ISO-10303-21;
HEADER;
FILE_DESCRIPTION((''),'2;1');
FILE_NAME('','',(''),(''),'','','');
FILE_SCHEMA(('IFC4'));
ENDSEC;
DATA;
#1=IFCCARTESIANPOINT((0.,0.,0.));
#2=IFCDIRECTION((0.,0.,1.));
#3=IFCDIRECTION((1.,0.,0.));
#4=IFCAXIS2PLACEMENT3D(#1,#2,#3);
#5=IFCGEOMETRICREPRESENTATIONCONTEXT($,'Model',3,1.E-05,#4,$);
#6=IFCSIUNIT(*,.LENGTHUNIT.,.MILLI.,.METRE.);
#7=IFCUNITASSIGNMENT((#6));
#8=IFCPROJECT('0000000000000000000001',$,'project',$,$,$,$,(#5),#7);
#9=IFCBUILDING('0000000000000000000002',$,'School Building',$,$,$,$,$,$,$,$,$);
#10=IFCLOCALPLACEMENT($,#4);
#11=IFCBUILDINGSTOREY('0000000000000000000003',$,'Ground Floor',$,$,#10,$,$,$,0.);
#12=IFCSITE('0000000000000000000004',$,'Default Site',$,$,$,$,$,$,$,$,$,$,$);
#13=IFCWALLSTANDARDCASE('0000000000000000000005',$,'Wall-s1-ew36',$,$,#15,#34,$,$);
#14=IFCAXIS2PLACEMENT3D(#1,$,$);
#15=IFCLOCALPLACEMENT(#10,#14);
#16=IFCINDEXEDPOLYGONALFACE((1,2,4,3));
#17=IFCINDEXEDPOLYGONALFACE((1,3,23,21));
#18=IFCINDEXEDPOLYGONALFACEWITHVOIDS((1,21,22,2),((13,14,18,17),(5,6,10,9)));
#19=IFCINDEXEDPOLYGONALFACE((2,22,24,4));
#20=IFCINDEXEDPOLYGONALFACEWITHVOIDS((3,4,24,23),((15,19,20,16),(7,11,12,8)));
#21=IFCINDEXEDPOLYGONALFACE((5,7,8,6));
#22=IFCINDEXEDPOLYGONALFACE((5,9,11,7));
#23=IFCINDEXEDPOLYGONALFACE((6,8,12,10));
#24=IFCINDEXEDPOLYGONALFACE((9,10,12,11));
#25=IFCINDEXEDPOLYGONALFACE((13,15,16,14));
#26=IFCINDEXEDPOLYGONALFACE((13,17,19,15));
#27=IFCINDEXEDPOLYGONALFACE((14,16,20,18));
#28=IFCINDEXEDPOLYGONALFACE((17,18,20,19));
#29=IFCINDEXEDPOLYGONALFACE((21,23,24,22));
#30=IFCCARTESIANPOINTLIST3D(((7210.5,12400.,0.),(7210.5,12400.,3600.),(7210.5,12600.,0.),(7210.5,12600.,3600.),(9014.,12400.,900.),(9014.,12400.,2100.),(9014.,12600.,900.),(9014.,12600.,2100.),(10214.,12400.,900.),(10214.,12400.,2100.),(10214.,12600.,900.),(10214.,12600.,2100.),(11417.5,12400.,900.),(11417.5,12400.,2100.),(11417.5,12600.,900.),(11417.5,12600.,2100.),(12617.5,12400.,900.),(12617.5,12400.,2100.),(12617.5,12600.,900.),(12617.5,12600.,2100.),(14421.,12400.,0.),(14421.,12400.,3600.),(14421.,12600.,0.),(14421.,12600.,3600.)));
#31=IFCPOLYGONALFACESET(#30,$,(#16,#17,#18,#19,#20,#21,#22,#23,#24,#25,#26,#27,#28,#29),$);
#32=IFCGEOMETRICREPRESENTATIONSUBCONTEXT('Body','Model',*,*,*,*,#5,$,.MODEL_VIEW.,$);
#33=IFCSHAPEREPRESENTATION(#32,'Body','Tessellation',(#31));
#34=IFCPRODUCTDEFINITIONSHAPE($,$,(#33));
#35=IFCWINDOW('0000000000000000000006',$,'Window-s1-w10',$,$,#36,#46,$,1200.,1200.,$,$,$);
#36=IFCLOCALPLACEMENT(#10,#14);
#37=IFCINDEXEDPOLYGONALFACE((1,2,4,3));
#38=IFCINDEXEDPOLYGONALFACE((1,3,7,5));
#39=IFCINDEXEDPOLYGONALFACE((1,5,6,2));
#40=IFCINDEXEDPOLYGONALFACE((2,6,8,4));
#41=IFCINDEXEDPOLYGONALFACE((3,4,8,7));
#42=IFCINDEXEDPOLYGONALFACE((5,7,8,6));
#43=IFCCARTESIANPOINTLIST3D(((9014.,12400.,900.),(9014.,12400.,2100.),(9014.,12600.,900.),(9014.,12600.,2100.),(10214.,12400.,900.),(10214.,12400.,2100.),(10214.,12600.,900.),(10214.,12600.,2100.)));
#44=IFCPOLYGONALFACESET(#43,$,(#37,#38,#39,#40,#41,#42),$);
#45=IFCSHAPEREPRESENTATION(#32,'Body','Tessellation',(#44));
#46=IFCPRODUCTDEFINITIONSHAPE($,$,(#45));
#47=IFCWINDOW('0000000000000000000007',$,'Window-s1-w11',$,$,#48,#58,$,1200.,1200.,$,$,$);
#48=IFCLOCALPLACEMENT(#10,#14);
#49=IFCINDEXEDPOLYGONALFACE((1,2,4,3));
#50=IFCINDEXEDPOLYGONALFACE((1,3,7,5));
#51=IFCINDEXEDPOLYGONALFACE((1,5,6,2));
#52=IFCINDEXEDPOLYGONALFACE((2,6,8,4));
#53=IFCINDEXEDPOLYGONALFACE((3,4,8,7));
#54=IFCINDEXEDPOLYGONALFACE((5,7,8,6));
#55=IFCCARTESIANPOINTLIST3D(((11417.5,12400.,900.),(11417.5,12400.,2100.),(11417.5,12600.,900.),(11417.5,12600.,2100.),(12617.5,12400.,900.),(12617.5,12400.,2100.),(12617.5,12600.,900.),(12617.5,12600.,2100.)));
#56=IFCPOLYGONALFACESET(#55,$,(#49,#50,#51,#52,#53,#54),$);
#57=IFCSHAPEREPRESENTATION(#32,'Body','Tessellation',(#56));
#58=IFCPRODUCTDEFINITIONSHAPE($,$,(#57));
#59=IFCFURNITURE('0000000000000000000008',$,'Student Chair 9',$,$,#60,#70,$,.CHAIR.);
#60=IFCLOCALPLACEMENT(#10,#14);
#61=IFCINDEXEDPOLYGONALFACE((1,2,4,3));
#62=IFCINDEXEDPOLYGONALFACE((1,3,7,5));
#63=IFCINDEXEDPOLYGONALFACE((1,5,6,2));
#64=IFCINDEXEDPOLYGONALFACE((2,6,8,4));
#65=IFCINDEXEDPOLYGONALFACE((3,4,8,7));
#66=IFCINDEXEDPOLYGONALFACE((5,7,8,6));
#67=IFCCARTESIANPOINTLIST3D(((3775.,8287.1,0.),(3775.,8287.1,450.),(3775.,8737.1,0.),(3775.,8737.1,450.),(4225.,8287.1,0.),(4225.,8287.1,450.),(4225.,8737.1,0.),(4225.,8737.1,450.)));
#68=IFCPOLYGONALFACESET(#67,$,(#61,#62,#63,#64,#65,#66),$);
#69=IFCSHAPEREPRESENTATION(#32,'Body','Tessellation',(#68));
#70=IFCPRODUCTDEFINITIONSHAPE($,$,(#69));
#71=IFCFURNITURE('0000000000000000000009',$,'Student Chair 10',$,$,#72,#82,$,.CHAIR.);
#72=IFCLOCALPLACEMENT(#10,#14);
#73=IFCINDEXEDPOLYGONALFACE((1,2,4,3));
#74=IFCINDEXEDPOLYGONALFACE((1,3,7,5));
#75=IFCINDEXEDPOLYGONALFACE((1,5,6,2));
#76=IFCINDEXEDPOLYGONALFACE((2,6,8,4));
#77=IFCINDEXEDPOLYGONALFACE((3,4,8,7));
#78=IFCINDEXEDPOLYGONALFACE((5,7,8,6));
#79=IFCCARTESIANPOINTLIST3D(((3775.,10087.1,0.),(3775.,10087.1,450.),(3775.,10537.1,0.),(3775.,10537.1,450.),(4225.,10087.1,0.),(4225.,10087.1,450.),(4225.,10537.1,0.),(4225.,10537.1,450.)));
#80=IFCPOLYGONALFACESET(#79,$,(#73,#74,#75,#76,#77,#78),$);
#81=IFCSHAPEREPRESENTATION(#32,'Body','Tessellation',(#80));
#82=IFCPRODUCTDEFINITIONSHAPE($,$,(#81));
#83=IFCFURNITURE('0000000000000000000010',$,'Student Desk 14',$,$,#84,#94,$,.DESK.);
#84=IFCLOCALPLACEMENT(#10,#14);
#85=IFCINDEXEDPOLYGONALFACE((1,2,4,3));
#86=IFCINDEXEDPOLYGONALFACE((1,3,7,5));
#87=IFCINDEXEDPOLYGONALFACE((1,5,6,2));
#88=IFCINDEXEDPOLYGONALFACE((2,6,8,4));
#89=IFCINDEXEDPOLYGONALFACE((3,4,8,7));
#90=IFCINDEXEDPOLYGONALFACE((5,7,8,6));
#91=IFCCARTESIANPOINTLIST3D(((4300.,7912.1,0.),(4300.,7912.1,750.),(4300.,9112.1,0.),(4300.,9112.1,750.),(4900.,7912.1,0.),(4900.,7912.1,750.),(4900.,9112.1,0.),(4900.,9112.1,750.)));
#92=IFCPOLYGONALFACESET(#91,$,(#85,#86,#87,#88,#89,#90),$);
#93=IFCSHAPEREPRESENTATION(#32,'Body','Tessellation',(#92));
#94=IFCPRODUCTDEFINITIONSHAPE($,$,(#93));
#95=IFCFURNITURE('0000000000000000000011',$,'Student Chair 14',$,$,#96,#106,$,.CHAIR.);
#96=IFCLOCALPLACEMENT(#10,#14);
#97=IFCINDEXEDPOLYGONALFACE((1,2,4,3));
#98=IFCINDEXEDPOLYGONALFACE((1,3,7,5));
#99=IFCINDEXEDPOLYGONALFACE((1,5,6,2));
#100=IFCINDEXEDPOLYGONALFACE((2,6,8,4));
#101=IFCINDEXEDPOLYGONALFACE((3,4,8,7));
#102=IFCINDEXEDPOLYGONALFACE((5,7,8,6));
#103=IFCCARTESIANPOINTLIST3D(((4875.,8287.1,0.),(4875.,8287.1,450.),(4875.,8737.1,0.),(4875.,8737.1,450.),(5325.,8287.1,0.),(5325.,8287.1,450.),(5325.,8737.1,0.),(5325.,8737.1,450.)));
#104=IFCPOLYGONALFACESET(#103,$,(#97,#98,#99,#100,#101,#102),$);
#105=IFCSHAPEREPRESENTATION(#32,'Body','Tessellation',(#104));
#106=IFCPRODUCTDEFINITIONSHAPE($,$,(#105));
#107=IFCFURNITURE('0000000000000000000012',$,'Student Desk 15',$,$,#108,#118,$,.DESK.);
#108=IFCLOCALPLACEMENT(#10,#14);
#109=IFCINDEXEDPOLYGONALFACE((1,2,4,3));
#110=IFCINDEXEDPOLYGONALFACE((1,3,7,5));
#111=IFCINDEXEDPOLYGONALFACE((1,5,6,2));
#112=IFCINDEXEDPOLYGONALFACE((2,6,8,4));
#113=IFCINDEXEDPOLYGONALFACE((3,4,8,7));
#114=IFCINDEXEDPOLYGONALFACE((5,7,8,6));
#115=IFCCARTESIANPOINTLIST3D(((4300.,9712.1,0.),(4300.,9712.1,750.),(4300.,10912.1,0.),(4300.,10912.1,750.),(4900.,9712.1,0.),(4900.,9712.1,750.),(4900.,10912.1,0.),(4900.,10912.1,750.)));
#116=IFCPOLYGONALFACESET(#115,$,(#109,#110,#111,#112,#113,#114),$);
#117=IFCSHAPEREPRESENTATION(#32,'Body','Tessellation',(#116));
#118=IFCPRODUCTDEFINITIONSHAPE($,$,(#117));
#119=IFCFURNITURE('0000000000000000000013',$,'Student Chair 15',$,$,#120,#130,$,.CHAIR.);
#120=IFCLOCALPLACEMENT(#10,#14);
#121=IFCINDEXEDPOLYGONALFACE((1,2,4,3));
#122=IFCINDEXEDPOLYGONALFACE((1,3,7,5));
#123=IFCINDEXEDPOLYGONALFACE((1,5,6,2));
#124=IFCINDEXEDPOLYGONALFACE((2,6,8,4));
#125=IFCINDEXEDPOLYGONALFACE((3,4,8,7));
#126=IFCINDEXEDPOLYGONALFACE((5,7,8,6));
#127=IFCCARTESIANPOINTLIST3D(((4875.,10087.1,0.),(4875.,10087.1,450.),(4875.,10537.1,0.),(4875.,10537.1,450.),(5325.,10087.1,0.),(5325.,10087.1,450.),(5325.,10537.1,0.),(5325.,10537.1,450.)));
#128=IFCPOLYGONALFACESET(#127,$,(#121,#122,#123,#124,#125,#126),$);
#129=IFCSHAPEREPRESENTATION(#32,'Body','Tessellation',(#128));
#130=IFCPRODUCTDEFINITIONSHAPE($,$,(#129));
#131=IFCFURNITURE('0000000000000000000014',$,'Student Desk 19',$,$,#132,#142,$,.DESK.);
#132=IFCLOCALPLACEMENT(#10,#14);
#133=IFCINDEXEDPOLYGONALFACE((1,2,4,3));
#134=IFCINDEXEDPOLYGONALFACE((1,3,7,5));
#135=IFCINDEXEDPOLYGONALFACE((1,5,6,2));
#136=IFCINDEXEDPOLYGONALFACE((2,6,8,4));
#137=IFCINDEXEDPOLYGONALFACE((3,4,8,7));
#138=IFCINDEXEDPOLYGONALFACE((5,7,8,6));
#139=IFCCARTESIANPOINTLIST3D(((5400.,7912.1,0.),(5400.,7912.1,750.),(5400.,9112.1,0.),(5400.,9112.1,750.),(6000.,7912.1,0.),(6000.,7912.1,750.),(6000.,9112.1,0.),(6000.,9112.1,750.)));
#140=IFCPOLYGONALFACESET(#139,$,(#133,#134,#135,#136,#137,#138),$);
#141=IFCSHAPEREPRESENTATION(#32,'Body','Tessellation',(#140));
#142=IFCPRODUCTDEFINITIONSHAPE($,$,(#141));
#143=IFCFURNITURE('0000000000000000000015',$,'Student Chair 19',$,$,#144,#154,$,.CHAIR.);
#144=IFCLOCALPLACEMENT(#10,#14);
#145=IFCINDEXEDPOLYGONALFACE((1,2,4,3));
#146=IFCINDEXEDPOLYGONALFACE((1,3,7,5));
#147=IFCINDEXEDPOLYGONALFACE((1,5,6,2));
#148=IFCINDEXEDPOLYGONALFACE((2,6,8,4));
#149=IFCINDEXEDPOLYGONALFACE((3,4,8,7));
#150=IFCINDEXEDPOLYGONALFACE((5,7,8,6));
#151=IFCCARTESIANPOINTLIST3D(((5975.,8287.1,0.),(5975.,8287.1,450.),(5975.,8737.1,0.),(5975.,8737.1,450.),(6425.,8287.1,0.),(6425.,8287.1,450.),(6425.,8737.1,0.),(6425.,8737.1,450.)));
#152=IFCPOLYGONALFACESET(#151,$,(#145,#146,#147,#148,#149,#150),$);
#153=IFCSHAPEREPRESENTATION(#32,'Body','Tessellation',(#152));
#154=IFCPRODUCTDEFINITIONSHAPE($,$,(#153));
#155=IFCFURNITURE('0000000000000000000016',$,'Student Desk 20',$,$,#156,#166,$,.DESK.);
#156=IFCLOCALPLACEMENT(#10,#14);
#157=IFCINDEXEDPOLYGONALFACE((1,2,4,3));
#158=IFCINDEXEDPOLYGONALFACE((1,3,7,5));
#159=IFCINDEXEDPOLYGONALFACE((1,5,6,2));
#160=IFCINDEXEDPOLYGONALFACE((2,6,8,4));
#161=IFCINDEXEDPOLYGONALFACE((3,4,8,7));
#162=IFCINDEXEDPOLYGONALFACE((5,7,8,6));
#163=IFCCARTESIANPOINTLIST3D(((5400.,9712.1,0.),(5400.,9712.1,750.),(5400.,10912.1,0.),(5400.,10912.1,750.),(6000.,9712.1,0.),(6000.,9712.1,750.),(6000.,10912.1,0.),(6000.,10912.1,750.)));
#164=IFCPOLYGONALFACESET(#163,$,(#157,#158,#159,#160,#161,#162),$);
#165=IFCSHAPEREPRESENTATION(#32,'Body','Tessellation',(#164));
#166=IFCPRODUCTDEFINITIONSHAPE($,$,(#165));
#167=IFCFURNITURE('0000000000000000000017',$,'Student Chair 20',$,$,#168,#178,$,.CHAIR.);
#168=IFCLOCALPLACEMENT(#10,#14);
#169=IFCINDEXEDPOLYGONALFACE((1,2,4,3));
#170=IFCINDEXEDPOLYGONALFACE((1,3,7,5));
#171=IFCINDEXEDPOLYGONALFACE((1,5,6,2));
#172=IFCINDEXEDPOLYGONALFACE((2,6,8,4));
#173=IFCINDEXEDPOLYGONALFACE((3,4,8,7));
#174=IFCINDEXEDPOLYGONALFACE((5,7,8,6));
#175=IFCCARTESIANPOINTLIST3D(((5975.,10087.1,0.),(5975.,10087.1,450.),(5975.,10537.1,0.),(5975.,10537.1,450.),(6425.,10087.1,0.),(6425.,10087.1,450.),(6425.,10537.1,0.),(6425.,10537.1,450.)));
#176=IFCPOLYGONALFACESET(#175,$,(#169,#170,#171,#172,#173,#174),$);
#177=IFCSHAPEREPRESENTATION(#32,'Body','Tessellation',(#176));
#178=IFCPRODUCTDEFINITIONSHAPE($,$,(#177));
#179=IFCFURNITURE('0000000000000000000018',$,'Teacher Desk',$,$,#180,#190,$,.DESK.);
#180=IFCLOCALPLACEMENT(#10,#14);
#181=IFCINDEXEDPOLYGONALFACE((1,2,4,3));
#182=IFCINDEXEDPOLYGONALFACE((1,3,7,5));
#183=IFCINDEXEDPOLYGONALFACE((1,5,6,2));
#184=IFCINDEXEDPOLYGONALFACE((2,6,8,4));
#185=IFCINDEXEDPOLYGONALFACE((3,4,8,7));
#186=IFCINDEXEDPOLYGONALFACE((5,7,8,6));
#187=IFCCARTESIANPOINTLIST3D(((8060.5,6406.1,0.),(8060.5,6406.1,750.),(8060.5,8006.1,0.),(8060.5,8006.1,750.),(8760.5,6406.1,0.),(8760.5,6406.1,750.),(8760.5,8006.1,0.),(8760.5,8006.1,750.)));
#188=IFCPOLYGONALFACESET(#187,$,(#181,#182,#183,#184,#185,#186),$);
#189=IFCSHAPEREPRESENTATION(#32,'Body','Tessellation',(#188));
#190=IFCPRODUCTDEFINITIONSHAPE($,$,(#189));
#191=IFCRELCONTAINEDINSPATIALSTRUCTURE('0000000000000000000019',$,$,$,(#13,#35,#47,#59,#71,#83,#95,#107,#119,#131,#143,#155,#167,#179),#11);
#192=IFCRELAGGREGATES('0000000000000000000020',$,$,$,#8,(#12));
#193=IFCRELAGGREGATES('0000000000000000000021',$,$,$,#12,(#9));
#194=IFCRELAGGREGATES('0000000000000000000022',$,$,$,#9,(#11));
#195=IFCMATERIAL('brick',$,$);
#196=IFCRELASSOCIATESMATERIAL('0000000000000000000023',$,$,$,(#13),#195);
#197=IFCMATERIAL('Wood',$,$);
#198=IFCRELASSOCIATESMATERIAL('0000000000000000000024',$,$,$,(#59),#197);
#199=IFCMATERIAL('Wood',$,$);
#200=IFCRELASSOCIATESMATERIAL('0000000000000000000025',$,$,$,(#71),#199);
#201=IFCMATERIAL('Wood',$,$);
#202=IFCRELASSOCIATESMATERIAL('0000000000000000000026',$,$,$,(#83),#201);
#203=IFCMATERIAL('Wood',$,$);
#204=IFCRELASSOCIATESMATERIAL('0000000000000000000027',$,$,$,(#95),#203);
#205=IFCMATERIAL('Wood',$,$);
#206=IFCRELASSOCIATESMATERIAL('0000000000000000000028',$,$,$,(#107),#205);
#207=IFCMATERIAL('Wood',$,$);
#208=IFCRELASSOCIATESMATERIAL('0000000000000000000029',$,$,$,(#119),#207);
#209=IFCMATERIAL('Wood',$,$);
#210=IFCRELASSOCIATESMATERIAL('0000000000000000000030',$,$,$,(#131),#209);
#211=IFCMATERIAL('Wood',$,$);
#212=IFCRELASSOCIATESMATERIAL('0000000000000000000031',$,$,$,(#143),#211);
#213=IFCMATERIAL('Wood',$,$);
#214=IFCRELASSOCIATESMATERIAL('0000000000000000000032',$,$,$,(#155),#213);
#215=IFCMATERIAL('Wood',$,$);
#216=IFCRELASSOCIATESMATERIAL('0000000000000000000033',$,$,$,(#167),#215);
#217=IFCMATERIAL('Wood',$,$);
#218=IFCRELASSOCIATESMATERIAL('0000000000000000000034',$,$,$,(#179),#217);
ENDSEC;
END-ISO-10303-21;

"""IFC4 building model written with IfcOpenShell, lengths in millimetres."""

from ifc_helpers import new_model, si_unit, frame, frame_2d, origin_with_axes, origin_2d, place, context, subcontext, project, spatial, rectangle, extrude, material, element, fill, save


model = new_model("IFC4")

# Units and contexts
model_context = context("Model", 3, precision=1e-05, world=origin_with_axes())
body_context = subcontext(model_context, "Body", "Model", "MODEL_VIEW")
ifc_project = project(units=[si_unit("LENGTHUNIT", "METRE", prefix="MILLI")], contexts=[model_context])

# Site, building, storey
site = spatial("IfcSite", under=ifc_project, Name="Default Site")
building = spatial("IfcBuilding", under=site, Name="School Building")
storey_placement = place(None, origin_with_axes())
storey = spatial("IfcBuildingStorey", under=building, at=storey_placement, Name="Ground Floor", Elevation=0.0)

# Wall, openings, windows
ifc_material_1 = material(Name="brick")
wall_placement = place(storey_placement, frame((7210.5, 12500.0, 0.0), z_axis=(0.0, 0.0, 1.0), x_axis=(1.0, 0.0, 0.0)))
wall = element("IfcWallStandardCase", 1, at=wall_placement, inside=storey, material=ifc_material_1, Name="Wall-s1-ew36", context=body_context, shape_type="SweptSolid", body=[
    extrude(rectangle(XDim=7210.5, YDim=200.0, at=frame_2d((3605.2, 0.0))), origin_with_axes(), (0.0, 0.0, 1.0), 3600.0),
])
opening_1_placement = place(wall_placement, frame((1803.5, 0.0, 900.0), z_axis=(0.0, 0.0, 1.0), x_axis=(1.0, 0.0, 0.0)))
opening_1 = element("IfcOpeningElement", 2, at=opening_1_placement, cuts=wall, context=body_context, shape_type="SweptSolid", body=[
    extrude(rectangle(XDim=1200.0, YDim=400.0, at=frame_2d((600.0, 0.0))), origin_with_axes(), (0.0, 0.0, 1.0), 1200.0),
])
opening_2_placement = place(wall_placement, frame((4207.0, 0.0, 900.0), z_axis=(0.0, 0.0, 1.0), x_axis=(1.0, 0.0, 0.0)))
opening_2 = element("IfcOpeningElement", 3, at=opening_2_placement, cuts=wall, context=body_context, shape_type="SweptSolid", body=[
    extrude(rectangle(XDim=1200.0, YDim=400.0, at=frame_2d((600.0, 0.0))), origin_with_axes(), (0.0, 0.0, 1.0), 1200.0),
])
window_1_placement = place(storey_placement, frame((9014.0, 12500.0, 900.0), z_axis=(0.0, 0.0, 1.0), x_axis=(1.0, 0.0, 0.0)))
window_1 = element("IfcWindow", 4, at=window_1_placement, inside=storey, Name="Window-s1-w10", OverallHeight=1200.0, OverallWidth=1200.0, context=body_context, shape_type="SweptSolid", body=[
    extrude(rectangle(XDim=1200.0, YDim=200.0, at=frame_2d((600.0, 0.0))), origin_with_axes(), (0.0, 0.0, 1.0), 1200.0),
])
fill(opening_1, window_1)
window_2_placement = place(storey_placement, frame((11417.5, 12500.0, 900.0), z_axis=(0.0, 0.0, 1.0), x_axis=(1.0, 0.0, 0.0)))
window_2 = element("IfcWindow", 5, at=window_2_placement, inside=storey, Name="Window-s1-w11", OverallHeight=1200.0, OverallWidth=1200.0, context=body_context, shape_type="SweptSolid", body=[
    extrude(rectangle(XDim=1200.0, YDim=200.0, at=frame_2d((600.0, 0.0))), origin_with_axes(), (0.0, 0.0, 1.0), 1200.0),
])
fill(opening_2, window_2)

# Furniture
ifc_material_2 = material(Name="Wood")
furniture_1_placement = place(storey_placement, frame((4000.0, 8512.1, 0.0), z_axis=(0.0, 0.0, 1.0), x_axis=(1.0, 0.0, 0.0)))
element("IfcFurniture", 6, at=furniture_1_placement, inside=storey, material=ifc_material_2, Name="Student Chair 9", PredefinedType="CHAIR", context=body_context, shape_type="SweptSolid", body=[
    extrude(rectangle(XDim=450.0, YDim=450.0, at=origin_2d()), origin_with_axes(), (0.0, 0.0, 1.0), 450.0),
])
ifc_material_3 = material(Name="Wood")
furniture_2_placement = place(storey_placement, frame((4000.0, 10312.1, 0.0), z_axis=(0.0, 0.0, 1.0), x_axis=(1.0, 0.0, 0.0)))
element("IfcFurniture", 7, at=furniture_2_placement, inside=storey, material=ifc_material_3, Name="Student Chair 10", PredefinedType="CHAIR", context=body_context, shape_type="SweptSolid", body=[
    extrude(rectangle(XDim=450.0, YDim=450.0, at=origin_2d()), origin_with_axes(), (0.0, 0.0, 1.0), 450.0),
])
ifc_material_4 = material(Name="Wood")
furniture_3_placement = place(storey_placement, frame((4600.0, 8512.1, 0.0), z_axis=(0.0, 0.0, 1.0), x_axis=(0.0, 1.0, 0.0)))
element("IfcFurniture", 8, at=furniture_3_placement, inside=storey, material=ifc_material_4, Name="Student Desk 14", PredefinedType="DESK", context=body_context, shape_type="SweptSolid", body=[
    extrude(rectangle(XDim=1200.0, YDim=600.0, at=origin_2d()), origin_with_axes(), (0.0, 0.0, 1.0), 750.0),
])
ifc_material_5 = material(Name="Wood")
furniture_4_placement = place(storey_placement, frame((5100.0, 8512.1, 0.0), z_axis=(0.0, 0.0, 1.0), x_axis=(1.0, 0.0, 0.0)))
element("IfcFurniture", 9, at=furniture_4_placement, inside=storey, material=ifc_material_5, Name="Student Chair 14", PredefinedType="CHAIR", context=body_context, shape_type="SweptSolid", body=[
    extrude(rectangle(XDim=450.0, YDim=450.0, at=origin_2d()), origin_with_axes(), (0.0, 0.0, 1.0), 450.0),
])
ifc_material_6 = material(Name="Wood")
furniture_5_placement = place(storey_placement, frame((4600.0, 10312.1, 0.0), z_axis=(0.0, 0.0, 1.0), x_axis=(0.0, 1.0, 0.0)))
element("IfcFurniture", 10, at=furniture_5_placement, inside=storey, material=ifc_material_6, Name="Student Desk 15", PredefinedType="DESK", context=body_context, shape_type="SweptSolid", body=[
    extrude(rectangle(XDim=1200.0, YDim=600.0, at=origin_2d()), origin_with_axes(), (0.0, 0.0, 1.0), 750.0),
])
ifc_material_7 = material(Name="Wood")
furniture_6_placement = place(storey_placement, frame((5100.0, 10312.1, 0.0), z_axis=(0.0, 0.0, 1.0), x_axis=(1.0, 0.0, 0.0)))
element("IfcFurniture", 11, at=furniture_6_placement, inside=storey, material=ifc_material_7, Name="Student Chair 15", PredefinedType="CHAIR", context=body_context, shape_type="SweptSolid", body=[
    extrude(rectangle(XDim=450.0, YDim=450.0, at=origin_2d()), origin_with_axes(), (0.0, 0.0, 1.0), 450.0),
])
ifc_material_8 = material(Name="Wood")
furniture_7_placement = place(storey_placement, frame((5700.0, 8512.1, 0.0), z_axis=(0.0, 0.0, 1.0), x_axis=(0.0, 1.0, 0.0)))
element("IfcFurniture", 12, at=furniture_7_placement, inside=storey, material=ifc_material_8, Name="Student Desk 19", PredefinedType="DESK", context=body_context, shape_type="SweptSolid", body=[
    extrude(rectangle(XDim=1200.0, YDim=600.0, at=origin_2d()), origin_with_axes(), (0.0, 0.0, 1.0), 750.0),
])
ifc_material_9 = material(Name="Wood")
furniture_8_placement = place(storey_placement, frame((6200.0, 8512.1, 0.0), z_axis=(0.0, 0.0, 1.0), x_axis=(1.0, 0.0, 0.0)))
element("IfcFurniture", 13, at=furniture_8_placement, inside=storey, material=ifc_material_9, Name="Student Chair 19", PredefinedType="CHAIR", context=body_context, shape_type="SweptSolid", body=[
    extrude(rectangle(XDim=450.0, YDim=450.0, at=origin_2d()), origin_with_axes(), (0.0, 0.0, 1.0), 450.0),
])
ifc_material_10 = material(Name="Wood")
furniture_9_placement = place(storey_placement, frame((5700.0, 10312.1, 0.0), z_axis=(0.0, 0.0, 1.0), x_axis=(0.0, 1.0, 0.0)))
element("IfcFurniture", 14, at=furniture_9_placement, inside=storey, material=ifc_material_10, Name="Student Desk 20", PredefinedType="DESK", context=body_context, shape_type="SweptSolid", body=[
    extrude(rectangle(XDim=1200.0, YDim=600.0, at=origin_2d()), origin_with_axes(), (0.0, 0.0, 1.0), 750.0),
])
ifc_material_11 = material(Name="Wood")
furniture_10_placement = place(storey_placement, frame((6200.0, 10312.1, 0.0), z_axis=(0.0, 0.0, 1.0), x_axis=(1.0, 0.0, 0.0)))
element("IfcFurniture", 15, at=furniture_10_placement, inside=storey, material=ifc_material_11, Name="Student Chair 20", PredefinedType="CHAIR", context=body_context, shape_type="SweptSolid", body=[
    extrude(rectangle(XDim=450.0, YDim=450.0, at=origin_2d()), origin_with_axes(), (0.0, 0.0, 1.0), 450.0),
])
ifc_material_12 = material(Name="Wood")
furniture_11_placement = place(storey_placement, frame((8410.5, 7206.1, 0.0), z_axis=(0.0, 0.0, 1.0), x_axis=(0.0, 1.0, 0.0)))
element("IfcFurniture", 16, at=furniture_11_placement, inside=storey, material=ifc_material_12, Name="Teacher Desk", PredefinedType="DESK", context=body_context, shape_type="SweptSolid", body=[
    extrude(rectangle(XDim=1600.0, YDim=700.0, at=origin_2d()), origin_with_axes(), (0.0, 0.0, 1.0), 750.0),
])

save(model, "model.ifc")
